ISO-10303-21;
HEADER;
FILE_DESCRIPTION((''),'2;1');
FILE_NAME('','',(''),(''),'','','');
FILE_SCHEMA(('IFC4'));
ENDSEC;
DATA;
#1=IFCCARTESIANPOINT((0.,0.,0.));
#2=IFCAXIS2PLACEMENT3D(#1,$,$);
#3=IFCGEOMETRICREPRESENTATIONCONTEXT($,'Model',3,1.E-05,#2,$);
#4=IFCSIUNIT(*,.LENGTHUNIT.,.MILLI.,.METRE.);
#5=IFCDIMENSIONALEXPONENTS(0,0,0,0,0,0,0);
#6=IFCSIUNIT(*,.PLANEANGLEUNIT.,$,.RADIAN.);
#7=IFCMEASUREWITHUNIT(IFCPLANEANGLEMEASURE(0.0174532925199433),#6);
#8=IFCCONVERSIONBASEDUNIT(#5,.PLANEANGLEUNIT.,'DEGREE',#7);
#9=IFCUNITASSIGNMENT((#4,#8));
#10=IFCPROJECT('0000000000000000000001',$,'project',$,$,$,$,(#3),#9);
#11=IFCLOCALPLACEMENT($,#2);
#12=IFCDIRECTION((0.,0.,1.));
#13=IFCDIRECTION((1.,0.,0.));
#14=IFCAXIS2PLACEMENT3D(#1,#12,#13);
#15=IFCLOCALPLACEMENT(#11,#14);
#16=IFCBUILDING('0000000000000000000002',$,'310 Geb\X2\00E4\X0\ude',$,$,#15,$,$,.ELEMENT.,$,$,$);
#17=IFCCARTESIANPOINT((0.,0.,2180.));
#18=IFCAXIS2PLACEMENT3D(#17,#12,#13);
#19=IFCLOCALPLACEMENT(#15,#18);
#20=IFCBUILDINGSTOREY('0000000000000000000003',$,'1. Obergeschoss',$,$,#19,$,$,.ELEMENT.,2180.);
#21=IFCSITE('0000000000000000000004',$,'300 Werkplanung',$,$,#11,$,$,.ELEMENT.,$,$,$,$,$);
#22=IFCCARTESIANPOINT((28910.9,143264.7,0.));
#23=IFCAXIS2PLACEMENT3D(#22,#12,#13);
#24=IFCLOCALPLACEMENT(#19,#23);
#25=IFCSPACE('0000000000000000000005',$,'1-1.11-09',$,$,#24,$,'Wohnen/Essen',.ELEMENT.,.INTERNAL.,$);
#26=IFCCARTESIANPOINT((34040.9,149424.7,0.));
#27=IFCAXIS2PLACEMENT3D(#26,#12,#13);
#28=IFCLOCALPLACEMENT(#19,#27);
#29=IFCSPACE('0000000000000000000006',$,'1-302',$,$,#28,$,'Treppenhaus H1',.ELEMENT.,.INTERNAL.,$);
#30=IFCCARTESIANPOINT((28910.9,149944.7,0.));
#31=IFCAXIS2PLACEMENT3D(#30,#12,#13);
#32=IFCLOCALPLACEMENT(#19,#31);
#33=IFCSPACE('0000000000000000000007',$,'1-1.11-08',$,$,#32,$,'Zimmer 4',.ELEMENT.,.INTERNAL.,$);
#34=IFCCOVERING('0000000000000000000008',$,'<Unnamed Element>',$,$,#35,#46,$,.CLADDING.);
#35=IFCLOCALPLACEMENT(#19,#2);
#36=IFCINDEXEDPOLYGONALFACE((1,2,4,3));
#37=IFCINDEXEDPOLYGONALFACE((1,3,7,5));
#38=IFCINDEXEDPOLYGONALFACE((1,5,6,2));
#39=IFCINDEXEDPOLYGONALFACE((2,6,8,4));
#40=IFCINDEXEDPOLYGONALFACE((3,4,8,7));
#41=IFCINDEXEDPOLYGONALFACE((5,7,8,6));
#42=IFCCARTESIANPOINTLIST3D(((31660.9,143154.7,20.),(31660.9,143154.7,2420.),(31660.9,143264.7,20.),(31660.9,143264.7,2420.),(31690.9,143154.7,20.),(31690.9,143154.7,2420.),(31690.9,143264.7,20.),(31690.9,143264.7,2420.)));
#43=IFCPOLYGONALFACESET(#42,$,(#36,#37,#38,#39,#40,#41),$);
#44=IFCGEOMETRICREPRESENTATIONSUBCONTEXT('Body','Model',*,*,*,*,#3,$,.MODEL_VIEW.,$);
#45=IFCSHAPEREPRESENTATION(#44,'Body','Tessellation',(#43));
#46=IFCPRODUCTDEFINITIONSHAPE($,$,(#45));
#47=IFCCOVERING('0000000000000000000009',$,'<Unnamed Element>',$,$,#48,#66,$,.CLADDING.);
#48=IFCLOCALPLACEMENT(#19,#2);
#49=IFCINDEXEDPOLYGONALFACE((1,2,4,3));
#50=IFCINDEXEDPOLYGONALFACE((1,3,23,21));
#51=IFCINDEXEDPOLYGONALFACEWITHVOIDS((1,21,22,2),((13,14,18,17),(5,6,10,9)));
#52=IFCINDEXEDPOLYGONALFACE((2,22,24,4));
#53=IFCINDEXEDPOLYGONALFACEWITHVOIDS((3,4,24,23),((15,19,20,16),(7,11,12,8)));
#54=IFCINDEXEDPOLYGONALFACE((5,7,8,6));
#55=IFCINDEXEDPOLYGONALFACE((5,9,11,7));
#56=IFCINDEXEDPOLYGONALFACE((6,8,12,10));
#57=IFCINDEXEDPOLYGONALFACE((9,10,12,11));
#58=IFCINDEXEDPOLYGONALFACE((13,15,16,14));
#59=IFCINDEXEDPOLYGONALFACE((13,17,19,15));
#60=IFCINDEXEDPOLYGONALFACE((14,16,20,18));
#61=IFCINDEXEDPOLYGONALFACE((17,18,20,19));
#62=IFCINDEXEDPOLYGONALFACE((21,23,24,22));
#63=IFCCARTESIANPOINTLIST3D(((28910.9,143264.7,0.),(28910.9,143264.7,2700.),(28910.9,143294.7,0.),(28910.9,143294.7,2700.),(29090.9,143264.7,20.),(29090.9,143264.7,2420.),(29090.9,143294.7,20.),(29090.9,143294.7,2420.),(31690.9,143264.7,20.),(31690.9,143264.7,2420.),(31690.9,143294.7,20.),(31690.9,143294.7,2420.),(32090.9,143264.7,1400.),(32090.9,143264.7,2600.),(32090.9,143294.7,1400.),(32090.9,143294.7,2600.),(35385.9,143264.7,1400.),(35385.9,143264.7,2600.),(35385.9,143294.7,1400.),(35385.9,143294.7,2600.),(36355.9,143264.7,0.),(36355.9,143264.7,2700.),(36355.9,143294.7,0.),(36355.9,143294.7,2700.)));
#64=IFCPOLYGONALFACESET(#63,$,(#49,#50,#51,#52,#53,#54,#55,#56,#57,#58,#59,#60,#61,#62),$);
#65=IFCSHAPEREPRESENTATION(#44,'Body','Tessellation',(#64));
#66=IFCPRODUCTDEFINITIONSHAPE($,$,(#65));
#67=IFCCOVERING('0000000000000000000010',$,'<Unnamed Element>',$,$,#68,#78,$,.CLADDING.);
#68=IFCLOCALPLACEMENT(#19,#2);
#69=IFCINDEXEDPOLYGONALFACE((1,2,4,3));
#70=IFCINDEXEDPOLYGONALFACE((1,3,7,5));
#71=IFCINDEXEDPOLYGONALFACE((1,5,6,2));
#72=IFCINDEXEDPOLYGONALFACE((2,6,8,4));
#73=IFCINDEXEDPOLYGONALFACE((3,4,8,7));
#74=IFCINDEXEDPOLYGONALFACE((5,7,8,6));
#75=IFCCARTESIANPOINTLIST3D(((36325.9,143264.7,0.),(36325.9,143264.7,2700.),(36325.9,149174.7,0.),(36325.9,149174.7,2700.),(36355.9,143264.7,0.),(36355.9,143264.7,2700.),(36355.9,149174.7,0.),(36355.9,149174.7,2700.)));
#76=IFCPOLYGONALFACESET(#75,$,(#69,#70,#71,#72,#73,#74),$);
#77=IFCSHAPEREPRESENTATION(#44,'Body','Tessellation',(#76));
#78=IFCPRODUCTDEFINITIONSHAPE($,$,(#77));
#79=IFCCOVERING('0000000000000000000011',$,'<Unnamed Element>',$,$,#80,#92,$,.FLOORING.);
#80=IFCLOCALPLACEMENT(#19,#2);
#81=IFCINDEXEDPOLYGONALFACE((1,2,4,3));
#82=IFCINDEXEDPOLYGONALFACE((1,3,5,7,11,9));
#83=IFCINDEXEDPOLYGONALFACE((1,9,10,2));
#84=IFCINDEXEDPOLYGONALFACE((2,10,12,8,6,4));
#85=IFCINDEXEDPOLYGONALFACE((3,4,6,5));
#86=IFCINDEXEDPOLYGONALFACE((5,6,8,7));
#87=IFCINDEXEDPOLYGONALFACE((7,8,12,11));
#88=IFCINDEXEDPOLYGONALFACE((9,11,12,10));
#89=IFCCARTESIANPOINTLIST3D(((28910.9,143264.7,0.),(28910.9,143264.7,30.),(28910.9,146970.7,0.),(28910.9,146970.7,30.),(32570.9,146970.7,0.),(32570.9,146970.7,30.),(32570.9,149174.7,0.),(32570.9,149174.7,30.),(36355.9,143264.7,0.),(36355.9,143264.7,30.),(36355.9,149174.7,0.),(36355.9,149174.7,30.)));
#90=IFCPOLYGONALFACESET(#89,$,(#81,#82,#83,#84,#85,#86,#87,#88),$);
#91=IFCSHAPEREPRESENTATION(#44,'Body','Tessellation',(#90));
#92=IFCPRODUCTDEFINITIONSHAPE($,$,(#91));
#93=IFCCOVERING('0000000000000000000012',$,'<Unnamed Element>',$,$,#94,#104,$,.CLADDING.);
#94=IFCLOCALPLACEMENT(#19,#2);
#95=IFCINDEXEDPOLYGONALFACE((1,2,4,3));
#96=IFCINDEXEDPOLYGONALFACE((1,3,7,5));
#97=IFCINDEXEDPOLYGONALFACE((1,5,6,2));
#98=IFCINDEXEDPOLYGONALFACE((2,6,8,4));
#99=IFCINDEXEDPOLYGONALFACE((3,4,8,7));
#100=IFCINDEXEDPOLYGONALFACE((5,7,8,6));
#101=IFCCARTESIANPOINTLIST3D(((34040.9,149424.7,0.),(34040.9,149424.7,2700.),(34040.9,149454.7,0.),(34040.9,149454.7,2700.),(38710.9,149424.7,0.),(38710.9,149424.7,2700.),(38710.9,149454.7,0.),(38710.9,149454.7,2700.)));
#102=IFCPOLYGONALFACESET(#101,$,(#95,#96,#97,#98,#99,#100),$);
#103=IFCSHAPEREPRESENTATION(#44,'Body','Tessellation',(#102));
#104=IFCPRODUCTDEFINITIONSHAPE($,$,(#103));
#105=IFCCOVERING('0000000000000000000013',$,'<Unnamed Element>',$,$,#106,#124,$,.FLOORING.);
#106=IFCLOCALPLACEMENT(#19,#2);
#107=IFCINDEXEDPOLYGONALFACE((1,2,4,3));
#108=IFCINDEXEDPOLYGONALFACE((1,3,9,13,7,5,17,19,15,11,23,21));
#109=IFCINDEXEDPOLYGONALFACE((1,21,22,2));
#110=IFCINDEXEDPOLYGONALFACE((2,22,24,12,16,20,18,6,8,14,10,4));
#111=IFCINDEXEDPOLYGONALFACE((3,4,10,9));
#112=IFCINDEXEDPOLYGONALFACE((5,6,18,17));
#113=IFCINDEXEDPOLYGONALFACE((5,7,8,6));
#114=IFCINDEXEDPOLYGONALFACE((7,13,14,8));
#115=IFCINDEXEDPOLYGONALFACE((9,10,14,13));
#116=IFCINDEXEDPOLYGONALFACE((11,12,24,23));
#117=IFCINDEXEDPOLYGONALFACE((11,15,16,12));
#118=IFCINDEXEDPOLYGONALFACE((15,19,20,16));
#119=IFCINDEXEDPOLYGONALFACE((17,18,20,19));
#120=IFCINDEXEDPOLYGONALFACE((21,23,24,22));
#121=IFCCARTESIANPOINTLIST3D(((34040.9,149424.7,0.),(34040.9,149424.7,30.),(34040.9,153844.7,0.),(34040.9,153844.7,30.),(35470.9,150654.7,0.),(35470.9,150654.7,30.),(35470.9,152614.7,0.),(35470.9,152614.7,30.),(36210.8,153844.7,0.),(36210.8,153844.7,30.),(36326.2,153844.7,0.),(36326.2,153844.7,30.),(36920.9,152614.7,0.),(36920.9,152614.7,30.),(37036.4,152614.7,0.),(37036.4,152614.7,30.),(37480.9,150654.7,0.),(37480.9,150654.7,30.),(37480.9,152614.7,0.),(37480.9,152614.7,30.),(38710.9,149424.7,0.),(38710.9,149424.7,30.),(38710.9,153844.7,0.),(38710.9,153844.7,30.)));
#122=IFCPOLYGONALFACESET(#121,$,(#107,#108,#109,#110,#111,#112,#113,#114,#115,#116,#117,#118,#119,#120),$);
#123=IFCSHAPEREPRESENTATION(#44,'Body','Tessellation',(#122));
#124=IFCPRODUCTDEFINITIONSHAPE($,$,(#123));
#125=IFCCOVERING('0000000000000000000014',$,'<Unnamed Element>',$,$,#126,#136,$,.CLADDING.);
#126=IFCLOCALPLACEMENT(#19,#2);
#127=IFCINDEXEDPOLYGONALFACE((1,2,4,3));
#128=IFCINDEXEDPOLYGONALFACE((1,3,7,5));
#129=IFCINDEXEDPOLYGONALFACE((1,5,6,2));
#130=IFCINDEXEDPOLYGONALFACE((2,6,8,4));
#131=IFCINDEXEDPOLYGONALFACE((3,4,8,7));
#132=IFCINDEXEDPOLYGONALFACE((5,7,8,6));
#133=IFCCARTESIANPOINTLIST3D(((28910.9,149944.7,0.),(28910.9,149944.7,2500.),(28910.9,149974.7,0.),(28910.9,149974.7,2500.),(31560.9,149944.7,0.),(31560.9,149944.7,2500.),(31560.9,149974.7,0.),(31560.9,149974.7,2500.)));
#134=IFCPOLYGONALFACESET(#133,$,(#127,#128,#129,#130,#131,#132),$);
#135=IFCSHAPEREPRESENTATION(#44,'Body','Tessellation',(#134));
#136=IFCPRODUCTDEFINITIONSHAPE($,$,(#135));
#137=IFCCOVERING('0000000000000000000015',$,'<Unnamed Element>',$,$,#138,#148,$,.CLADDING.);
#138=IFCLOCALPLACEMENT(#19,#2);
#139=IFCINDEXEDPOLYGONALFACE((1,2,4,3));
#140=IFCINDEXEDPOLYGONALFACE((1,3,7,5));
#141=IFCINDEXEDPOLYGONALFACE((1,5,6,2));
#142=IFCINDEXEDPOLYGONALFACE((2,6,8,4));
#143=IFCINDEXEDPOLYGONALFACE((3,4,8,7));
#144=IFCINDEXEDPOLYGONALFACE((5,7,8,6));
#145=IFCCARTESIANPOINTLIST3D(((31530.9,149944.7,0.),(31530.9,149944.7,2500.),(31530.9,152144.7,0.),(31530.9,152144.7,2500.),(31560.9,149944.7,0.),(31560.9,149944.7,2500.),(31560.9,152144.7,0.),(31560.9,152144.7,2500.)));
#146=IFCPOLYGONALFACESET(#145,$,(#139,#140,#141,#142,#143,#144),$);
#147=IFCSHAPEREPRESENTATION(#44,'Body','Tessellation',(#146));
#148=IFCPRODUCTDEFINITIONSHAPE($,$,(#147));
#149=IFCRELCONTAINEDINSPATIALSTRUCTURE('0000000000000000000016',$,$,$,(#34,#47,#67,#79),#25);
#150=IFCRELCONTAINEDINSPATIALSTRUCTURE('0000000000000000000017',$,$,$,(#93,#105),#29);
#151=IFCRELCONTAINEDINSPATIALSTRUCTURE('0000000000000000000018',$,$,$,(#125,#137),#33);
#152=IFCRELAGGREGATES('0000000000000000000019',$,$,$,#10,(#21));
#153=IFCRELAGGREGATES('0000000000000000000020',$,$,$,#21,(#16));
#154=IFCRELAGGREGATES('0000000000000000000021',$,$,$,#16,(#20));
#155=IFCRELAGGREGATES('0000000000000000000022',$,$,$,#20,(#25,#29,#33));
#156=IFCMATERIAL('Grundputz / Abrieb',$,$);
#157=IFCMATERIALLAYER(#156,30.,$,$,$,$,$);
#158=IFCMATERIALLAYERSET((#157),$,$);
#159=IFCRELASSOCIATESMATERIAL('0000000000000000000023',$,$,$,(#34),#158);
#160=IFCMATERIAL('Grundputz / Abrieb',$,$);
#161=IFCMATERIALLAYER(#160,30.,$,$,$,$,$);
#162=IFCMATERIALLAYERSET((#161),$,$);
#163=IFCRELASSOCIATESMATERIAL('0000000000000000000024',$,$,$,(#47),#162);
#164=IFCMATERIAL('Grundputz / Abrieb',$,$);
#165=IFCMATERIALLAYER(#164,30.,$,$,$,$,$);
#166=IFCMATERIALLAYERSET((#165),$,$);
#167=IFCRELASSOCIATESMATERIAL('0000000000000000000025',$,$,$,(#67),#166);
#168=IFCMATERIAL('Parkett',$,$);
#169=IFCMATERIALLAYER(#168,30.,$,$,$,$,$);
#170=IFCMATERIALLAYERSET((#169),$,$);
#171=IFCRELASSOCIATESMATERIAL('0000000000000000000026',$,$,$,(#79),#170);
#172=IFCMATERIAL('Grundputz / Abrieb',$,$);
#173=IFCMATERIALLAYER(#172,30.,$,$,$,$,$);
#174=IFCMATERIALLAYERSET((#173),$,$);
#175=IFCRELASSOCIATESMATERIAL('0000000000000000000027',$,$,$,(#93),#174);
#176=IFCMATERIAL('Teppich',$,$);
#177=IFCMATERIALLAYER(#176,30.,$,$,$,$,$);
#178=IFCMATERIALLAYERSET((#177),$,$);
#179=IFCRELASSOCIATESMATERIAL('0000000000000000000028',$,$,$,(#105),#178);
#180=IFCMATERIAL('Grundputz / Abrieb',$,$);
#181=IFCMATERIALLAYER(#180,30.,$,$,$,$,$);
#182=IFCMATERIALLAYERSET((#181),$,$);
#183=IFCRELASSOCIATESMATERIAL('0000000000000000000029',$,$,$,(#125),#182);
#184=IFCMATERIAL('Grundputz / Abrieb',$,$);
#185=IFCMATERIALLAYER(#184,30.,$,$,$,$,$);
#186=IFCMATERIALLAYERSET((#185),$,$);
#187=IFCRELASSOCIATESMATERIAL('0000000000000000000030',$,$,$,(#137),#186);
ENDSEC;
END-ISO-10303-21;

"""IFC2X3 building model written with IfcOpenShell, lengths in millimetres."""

from ifc_helpers import new_model, entity, si_unit, converted_unit, frame, frame_2d, origin, origin_with_axes, place, context, subcontext, project, spatial, polyline, rectangle, outline, extrude, material, layer, layer_set, layer_usage, element, save


model = new_model("IFC2X3")

# Units and contexts
model_context = context("Model", 3, precision=1e-05, world=origin())
body_context = subcontext(model_context, "Body", "Model", "MODEL_VIEW")
ifc_project = project(units=[si_unit("LENGTHUNIT", "METRE", prefix="MILLI"), converted_unit("PLANEANGLEUNIT", "DEGREE", entity("IfcPlaneAngleMeasure", 0.0174532925199433), si_unit("PLANEANGLEUNIT", "RADIAN"), dimensions=[0, 0, 0, 0, 0, 0, 0])], contexts=[model_context])

# Site, building, storey
site_placement = place(None, origin())
site = spatial("IfcSite", under=ifc_project, at=site_placement, Name="300 Werkplanung", CompositionType="ELEMENT")
building_placement = place(site_placement, origin_with_axes())
building = spatial("IfcBuilding", under=site, at=building_placement, Name="310 Gebäude", CompositionType="ELEMENT")
storey_placement = place(building_placement, frame((0.0, 0.0, 2180.0), z_axis=(0.0, 0.0, 1.0), x_axis=(1.0, 0.0, 0.0)))
storey = spatial("IfcBuildingStorey", under=building, at=storey_placement, Name="1. Obergeschoss", CompositionType="ELEMENT", Elevation=2180.0)

# Shared definitions
space_1_placement = place(storey_placement, frame((28910.9, 143264.7, 0.0), z_axis=(0.0, 0.0, 1.0), x_axis=(1.0, 0.0, 0.0)))
space_1 = spatial("IfcSpace", under=storey, at=space_1_placement, Name="1-1.11-09", LongName="Wohnen/Essen", CompositionType="ELEMENT", InteriorOrExteriorSpace="INTERNAL")

# Coverings
ifc_material_1 = material(Name="Grundputz / Abrieb")
ifc_layer_1 = layer(ifc_material_1, 30.0)
ifc_layer_set_1 = layer_set([ifc_layer_1])
ifc_layer_usage_1 = layer_usage(ifc_layer_set_1, "AXIS3", "POSITIVE", 0.0)
covering_1_placement = place(space_1_placement, frame((2780.0, -110.0, 20.0), z_axis=(0.0, 0.0, 1.0), x_axis=(0.0, 1.0, 0.0)))
element("IfcCovering", 1, at=covering_1_placement, inside=space_1, material=ifc_layer_usage_1, Name="<Unnamed Element>", PredefinedType="CLADDING", context=body_context, shape_type="SweptSolid", body=[
    extrude(rectangle(XDim=2400.0, YDim=110.0, at=frame_2d((-55.0, 1200.0), x_axis=(0.0, 1.0))), frame((110.0, 0.0, 2400.0), z_axis=(0.0, 1.0, 0.0), x_axis=(1.0, 0.0, 0.0)), (0.0, 0.0, 1.0), 30.0),
])
ifc_material_2 = material(Name="Grundputz / Abrieb")
ifc_layer_2 = layer(ifc_material_2, 30.0)
ifc_layer_set_2 = layer_set([ifc_layer_2])
ifc_layer_usage_2 = layer_usage(ifc_layer_set_2, "AXIS3", "POSITIVE", 0.0)
covering_2_placement = place(space_1_placement, frame((0.0, 0.0, 0.0), z_axis=(0.0, 0.0, 1.0), x_axis=(1.0, 0.0, 0.0)))
element("IfcCovering", 2, at=covering_2_placement, inside=space_1, material=ifc_layer_usage_2, Name="<Unnamed Element>", PredefinedType="CLADDING", context=body_context, shape_type="SweptSolid", body=[
    extrude(outline(polyline([(7445.0, 0.0), (7445.0, -2700.0), (0.0, -2700.0), (0.0, 0.0), (7445.0, 0.0)]), holes=[polyline([(6475.0, -1400.0), (3180.0, -1400.0), (3180.0, -2600.0), (6475.0, -2600.0), (6475.0, -1400.0)]), polyline([(2780.0, -20.0), (180.0, -20.0), (180.0, -2420.0), (2780.0, -2420.0), (2780.0, -20.0)])]), frame((0.0, 0.0, 0.0), z_axis=(0.0, 1.0, 0.0), x_axis=(1.0, 0.0, 0.0)), (0.0, 0.0, 1.0), 30.0),
])
ifc_material_3 = material(Name="Grundputz / Abrieb")
ifc_layer_3 = layer(ifc_material_3, 30.0)
ifc_layer_set_3 = layer_set([ifc_layer_3])
ifc_layer_usage_3 = layer_usage(ifc_layer_set_3, "AXIS3", "POSITIVE", 0.0)
covering_3_placement = place(space_1_placement, frame((7445.0, 0.0, 0.0), z_axis=(0.0, 0.0, 1.0), x_axis=(0.0, 1.0, 0.0)))
element("IfcCovering", 3, at=covering_3_placement, inside=space_1, material=ifc_layer_usage_3, Name="<Unnamed Element>", PredefinedType="CLADDING", context=body_context, shape_type="SweptSolid", body=[
    extrude(rectangle(XDim=2700.0, YDim=5910.0, at=frame_2d((-2955.0, 1350.0), x_axis=(0.0, 1.0))), frame((5910.0, 0.0, 2700.0), z_axis=(0.0, 1.0, 0.0), x_axis=(1.0, 0.0, 0.0)), (0.0, 0.0, 1.0), 30.0),
])
ifc_material_4 = material(Name="Parkett")
ifc_layer_4 = layer(ifc_material_4, 30.0)
ifc_layer_set_4 = layer_set([ifc_layer_4])
ifc_layer_usage_4 = layer_usage(ifc_layer_set_4, "AXIS3", "POSITIVE", 0.0)
covering_4_placement = place(space_1_placement, origin_with_axes())
element("IfcCovering", 4, at=covering_4_placement, inside=space_1, material=ifc_layer_usage_4, Name="<Unnamed Element>", PredefinedType="FLOORING", context=body_context, shape_type="SweptSolid", body=[
    extrude(outline(polyline([(3660.0, 3706.0), (0.0, 3706.0), (0.0, 0.0), (7445.0, 0.0), (7445.0, 5910.0), (3660.0, 5910.0), (3660.0, 3706.0)])), origin_with_axes(), (0.0, 0.0, 1.0), 30.0),
])

# Shared definitions
space_2_placement = place(storey_placement, frame((34040.9, 149424.7, 0.0), z_axis=(0.0, 0.0, 1.0), x_axis=(1.0, 0.0, 0.0)))
space_2 = spatial("IfcSpace", under=storey, at=space_2_placement, Name="1-302", LongName="Treppenhaus H1", CompositionType="ELEMENT", InteriorOrExteriorSpace="INTERNAL")

# Coverings
ifc_material_5 = material(Name="Grundputz / Abrieb")
ifc_layer_5 = layer(ifc_material_5, 30.0)
ifc_layer_set_5 = layer_set([ifc_layer_5])
ifc_layer_usage_5 = layer_usage(ifc_layer_set_5, "AXIS3", "POSITIVE", 0.0)
covering_5_placement = place(space_2_placement, origin_with_axes())
element("IfcCovering", 5, at=covering_5_placement, inside=space_2, material=ifc_layer_usage_5, Name="<Unnamed Element>", PredefinedType="CLADDING", context=body_context, shape_type="SweptSolid", body=[
    extrude(rectangle(XDim=2700.0, YDim=4670.0, at=frame_2d((-2335.0, 1350.0), x_axis=(0.0, 1.0))), frame((4670.0, 0.0, 2700.0), z_axis=(0.0, 1.0, 0.0), x_axis=(1.0, 0.0, 0.0)), (0.0, 0.0, 1.0), 30.0),
])
ifc_material_6 = material(Name="Teppich")
ifc_layer_6 = layer(ifc_material_6, 30.0)
ifc_layer_set_6 = layer_set([ifc_layer_6])
ifc_layer_usage_6 = layer_usage(ifc_layer_set_6, "AXIS3", "POSITIVE", 0.0)
covering_6_placement = place(space_2_placement, origin_with_axes())
element("IfcCovering", 6, at=covering_6_placement, inside=space_2, material=ifc_layer_usage_6, Name="<Unnamed Element>", PredefinedType="FLOORING", context=body_context, shape_type="SweptSolid", body=[
    extrude(outline(polyline([(2169.9, 4420.0), (0.0, 4420.0), (0.0, 0.0), (4670.0, 0.0), (4670.0, 4420.0), (2285.3, 4420.0), (2995.5, 3190.0), (3440.0, 3190.0), (3440.0, 1230.0), (1430.0, 1230.0), (1430.0, 3190.0), (2880.0, 3190.0), (2169.9, 4420.0)])), origin_with_axes(), (0.0, 0.0, 1.0), 30.0),
])

# Shared definitions
space_3_placement = place(storey_placement, frame((28910.9, 149944.7, 0.0), z_axis=(0.0, 0.0, 1.0), x_axis=(1.0, 0.0, 0.0)))
space_3 = spatial("IfcSpace", under=storey, at=space_3_placement, Name="1-1.11-08", LongName="Zimmer 4", CompositionType="ELEMENT", InteriorOrExteriorSpace="INTERNAL")

# Coverings
ifc_material_7 = material(Name="Grundputz / Abrieb")
ifc_layer_7 = layer(ifc_material_7, 30.0)
ifc_layer_set_7 = layer_set([ifc_layer_7])
ifc_layer_usage_7 = layer_usage(ifc_layer_set_7, "AXIS3", "POSITIVE", 0.0)
covering_7_placement = place(space_3_placement, frame((0.0, 0.0, 0.0), z_axis=(0.0, 0.0, 1.0), x_axis=(1.0, 0.0, 0.0)))
element("IfcCovering", 7, at=covering_7_placement, inside=space_3, material=ifc_layer_usage_7, Name="<Unnamed Element>", PredefinedType="CLADDING", context=body_context, shape_type="SweptSolid", body=[
    extrude(rectangle(XDim=2500.0, YDim=2650.0, at=frame_2d((-1325.0, 1250.0), x_axis=(0.0, 1.0))), frame((2650.0, 0.0, 2500.0), z_axis=(0.0, 1.0, 0.0), x_axis=(1.0, 0.0, 0.0)), (0.0, 0.0, 1.0), 30.0),
])
ifc_material_8 = material(Name="Grundputz / Abrieb")
ifc_layer_8 = layer(ifc_material_8, 30.0)
ifc_layer_set_8 = layer_set([ifc_layer_8])
ifc_layer_usage_8 = layer_usage(ifc_layer_set_8, "AXIS3", "POSITIVE", 0.0)
covering_8_placement = place(space_3_placement, frame((2650.0, 0.0, 0.0), z_axis=(0.0, 0.0, 1.0), x_axis=(0.0, 1.0, 0.0)))
element("IfcCovering", 8, at=covering_8_placement, inside=space_3, material=ifc_layer_usage_8, Name="<Unnamed Element>", PredefinedType="CLADDING", context=body_context, shape_type="SweptSolid", body=[
    extrude(rectangle(XDim=2500.0, YDim=2200.0, at=frame_2d((-1100.0, 1250.0), x_axis=(0.0, 1.0))), frame((2200.0, 0.0, 2500.0), z_axis=(0.0, 1.0, 0.0), x_axis=(1.0, 0.0, 0.0)), (0.0, 0.0, 1.0), 30.0),
])

save(model, "model.ifc")
